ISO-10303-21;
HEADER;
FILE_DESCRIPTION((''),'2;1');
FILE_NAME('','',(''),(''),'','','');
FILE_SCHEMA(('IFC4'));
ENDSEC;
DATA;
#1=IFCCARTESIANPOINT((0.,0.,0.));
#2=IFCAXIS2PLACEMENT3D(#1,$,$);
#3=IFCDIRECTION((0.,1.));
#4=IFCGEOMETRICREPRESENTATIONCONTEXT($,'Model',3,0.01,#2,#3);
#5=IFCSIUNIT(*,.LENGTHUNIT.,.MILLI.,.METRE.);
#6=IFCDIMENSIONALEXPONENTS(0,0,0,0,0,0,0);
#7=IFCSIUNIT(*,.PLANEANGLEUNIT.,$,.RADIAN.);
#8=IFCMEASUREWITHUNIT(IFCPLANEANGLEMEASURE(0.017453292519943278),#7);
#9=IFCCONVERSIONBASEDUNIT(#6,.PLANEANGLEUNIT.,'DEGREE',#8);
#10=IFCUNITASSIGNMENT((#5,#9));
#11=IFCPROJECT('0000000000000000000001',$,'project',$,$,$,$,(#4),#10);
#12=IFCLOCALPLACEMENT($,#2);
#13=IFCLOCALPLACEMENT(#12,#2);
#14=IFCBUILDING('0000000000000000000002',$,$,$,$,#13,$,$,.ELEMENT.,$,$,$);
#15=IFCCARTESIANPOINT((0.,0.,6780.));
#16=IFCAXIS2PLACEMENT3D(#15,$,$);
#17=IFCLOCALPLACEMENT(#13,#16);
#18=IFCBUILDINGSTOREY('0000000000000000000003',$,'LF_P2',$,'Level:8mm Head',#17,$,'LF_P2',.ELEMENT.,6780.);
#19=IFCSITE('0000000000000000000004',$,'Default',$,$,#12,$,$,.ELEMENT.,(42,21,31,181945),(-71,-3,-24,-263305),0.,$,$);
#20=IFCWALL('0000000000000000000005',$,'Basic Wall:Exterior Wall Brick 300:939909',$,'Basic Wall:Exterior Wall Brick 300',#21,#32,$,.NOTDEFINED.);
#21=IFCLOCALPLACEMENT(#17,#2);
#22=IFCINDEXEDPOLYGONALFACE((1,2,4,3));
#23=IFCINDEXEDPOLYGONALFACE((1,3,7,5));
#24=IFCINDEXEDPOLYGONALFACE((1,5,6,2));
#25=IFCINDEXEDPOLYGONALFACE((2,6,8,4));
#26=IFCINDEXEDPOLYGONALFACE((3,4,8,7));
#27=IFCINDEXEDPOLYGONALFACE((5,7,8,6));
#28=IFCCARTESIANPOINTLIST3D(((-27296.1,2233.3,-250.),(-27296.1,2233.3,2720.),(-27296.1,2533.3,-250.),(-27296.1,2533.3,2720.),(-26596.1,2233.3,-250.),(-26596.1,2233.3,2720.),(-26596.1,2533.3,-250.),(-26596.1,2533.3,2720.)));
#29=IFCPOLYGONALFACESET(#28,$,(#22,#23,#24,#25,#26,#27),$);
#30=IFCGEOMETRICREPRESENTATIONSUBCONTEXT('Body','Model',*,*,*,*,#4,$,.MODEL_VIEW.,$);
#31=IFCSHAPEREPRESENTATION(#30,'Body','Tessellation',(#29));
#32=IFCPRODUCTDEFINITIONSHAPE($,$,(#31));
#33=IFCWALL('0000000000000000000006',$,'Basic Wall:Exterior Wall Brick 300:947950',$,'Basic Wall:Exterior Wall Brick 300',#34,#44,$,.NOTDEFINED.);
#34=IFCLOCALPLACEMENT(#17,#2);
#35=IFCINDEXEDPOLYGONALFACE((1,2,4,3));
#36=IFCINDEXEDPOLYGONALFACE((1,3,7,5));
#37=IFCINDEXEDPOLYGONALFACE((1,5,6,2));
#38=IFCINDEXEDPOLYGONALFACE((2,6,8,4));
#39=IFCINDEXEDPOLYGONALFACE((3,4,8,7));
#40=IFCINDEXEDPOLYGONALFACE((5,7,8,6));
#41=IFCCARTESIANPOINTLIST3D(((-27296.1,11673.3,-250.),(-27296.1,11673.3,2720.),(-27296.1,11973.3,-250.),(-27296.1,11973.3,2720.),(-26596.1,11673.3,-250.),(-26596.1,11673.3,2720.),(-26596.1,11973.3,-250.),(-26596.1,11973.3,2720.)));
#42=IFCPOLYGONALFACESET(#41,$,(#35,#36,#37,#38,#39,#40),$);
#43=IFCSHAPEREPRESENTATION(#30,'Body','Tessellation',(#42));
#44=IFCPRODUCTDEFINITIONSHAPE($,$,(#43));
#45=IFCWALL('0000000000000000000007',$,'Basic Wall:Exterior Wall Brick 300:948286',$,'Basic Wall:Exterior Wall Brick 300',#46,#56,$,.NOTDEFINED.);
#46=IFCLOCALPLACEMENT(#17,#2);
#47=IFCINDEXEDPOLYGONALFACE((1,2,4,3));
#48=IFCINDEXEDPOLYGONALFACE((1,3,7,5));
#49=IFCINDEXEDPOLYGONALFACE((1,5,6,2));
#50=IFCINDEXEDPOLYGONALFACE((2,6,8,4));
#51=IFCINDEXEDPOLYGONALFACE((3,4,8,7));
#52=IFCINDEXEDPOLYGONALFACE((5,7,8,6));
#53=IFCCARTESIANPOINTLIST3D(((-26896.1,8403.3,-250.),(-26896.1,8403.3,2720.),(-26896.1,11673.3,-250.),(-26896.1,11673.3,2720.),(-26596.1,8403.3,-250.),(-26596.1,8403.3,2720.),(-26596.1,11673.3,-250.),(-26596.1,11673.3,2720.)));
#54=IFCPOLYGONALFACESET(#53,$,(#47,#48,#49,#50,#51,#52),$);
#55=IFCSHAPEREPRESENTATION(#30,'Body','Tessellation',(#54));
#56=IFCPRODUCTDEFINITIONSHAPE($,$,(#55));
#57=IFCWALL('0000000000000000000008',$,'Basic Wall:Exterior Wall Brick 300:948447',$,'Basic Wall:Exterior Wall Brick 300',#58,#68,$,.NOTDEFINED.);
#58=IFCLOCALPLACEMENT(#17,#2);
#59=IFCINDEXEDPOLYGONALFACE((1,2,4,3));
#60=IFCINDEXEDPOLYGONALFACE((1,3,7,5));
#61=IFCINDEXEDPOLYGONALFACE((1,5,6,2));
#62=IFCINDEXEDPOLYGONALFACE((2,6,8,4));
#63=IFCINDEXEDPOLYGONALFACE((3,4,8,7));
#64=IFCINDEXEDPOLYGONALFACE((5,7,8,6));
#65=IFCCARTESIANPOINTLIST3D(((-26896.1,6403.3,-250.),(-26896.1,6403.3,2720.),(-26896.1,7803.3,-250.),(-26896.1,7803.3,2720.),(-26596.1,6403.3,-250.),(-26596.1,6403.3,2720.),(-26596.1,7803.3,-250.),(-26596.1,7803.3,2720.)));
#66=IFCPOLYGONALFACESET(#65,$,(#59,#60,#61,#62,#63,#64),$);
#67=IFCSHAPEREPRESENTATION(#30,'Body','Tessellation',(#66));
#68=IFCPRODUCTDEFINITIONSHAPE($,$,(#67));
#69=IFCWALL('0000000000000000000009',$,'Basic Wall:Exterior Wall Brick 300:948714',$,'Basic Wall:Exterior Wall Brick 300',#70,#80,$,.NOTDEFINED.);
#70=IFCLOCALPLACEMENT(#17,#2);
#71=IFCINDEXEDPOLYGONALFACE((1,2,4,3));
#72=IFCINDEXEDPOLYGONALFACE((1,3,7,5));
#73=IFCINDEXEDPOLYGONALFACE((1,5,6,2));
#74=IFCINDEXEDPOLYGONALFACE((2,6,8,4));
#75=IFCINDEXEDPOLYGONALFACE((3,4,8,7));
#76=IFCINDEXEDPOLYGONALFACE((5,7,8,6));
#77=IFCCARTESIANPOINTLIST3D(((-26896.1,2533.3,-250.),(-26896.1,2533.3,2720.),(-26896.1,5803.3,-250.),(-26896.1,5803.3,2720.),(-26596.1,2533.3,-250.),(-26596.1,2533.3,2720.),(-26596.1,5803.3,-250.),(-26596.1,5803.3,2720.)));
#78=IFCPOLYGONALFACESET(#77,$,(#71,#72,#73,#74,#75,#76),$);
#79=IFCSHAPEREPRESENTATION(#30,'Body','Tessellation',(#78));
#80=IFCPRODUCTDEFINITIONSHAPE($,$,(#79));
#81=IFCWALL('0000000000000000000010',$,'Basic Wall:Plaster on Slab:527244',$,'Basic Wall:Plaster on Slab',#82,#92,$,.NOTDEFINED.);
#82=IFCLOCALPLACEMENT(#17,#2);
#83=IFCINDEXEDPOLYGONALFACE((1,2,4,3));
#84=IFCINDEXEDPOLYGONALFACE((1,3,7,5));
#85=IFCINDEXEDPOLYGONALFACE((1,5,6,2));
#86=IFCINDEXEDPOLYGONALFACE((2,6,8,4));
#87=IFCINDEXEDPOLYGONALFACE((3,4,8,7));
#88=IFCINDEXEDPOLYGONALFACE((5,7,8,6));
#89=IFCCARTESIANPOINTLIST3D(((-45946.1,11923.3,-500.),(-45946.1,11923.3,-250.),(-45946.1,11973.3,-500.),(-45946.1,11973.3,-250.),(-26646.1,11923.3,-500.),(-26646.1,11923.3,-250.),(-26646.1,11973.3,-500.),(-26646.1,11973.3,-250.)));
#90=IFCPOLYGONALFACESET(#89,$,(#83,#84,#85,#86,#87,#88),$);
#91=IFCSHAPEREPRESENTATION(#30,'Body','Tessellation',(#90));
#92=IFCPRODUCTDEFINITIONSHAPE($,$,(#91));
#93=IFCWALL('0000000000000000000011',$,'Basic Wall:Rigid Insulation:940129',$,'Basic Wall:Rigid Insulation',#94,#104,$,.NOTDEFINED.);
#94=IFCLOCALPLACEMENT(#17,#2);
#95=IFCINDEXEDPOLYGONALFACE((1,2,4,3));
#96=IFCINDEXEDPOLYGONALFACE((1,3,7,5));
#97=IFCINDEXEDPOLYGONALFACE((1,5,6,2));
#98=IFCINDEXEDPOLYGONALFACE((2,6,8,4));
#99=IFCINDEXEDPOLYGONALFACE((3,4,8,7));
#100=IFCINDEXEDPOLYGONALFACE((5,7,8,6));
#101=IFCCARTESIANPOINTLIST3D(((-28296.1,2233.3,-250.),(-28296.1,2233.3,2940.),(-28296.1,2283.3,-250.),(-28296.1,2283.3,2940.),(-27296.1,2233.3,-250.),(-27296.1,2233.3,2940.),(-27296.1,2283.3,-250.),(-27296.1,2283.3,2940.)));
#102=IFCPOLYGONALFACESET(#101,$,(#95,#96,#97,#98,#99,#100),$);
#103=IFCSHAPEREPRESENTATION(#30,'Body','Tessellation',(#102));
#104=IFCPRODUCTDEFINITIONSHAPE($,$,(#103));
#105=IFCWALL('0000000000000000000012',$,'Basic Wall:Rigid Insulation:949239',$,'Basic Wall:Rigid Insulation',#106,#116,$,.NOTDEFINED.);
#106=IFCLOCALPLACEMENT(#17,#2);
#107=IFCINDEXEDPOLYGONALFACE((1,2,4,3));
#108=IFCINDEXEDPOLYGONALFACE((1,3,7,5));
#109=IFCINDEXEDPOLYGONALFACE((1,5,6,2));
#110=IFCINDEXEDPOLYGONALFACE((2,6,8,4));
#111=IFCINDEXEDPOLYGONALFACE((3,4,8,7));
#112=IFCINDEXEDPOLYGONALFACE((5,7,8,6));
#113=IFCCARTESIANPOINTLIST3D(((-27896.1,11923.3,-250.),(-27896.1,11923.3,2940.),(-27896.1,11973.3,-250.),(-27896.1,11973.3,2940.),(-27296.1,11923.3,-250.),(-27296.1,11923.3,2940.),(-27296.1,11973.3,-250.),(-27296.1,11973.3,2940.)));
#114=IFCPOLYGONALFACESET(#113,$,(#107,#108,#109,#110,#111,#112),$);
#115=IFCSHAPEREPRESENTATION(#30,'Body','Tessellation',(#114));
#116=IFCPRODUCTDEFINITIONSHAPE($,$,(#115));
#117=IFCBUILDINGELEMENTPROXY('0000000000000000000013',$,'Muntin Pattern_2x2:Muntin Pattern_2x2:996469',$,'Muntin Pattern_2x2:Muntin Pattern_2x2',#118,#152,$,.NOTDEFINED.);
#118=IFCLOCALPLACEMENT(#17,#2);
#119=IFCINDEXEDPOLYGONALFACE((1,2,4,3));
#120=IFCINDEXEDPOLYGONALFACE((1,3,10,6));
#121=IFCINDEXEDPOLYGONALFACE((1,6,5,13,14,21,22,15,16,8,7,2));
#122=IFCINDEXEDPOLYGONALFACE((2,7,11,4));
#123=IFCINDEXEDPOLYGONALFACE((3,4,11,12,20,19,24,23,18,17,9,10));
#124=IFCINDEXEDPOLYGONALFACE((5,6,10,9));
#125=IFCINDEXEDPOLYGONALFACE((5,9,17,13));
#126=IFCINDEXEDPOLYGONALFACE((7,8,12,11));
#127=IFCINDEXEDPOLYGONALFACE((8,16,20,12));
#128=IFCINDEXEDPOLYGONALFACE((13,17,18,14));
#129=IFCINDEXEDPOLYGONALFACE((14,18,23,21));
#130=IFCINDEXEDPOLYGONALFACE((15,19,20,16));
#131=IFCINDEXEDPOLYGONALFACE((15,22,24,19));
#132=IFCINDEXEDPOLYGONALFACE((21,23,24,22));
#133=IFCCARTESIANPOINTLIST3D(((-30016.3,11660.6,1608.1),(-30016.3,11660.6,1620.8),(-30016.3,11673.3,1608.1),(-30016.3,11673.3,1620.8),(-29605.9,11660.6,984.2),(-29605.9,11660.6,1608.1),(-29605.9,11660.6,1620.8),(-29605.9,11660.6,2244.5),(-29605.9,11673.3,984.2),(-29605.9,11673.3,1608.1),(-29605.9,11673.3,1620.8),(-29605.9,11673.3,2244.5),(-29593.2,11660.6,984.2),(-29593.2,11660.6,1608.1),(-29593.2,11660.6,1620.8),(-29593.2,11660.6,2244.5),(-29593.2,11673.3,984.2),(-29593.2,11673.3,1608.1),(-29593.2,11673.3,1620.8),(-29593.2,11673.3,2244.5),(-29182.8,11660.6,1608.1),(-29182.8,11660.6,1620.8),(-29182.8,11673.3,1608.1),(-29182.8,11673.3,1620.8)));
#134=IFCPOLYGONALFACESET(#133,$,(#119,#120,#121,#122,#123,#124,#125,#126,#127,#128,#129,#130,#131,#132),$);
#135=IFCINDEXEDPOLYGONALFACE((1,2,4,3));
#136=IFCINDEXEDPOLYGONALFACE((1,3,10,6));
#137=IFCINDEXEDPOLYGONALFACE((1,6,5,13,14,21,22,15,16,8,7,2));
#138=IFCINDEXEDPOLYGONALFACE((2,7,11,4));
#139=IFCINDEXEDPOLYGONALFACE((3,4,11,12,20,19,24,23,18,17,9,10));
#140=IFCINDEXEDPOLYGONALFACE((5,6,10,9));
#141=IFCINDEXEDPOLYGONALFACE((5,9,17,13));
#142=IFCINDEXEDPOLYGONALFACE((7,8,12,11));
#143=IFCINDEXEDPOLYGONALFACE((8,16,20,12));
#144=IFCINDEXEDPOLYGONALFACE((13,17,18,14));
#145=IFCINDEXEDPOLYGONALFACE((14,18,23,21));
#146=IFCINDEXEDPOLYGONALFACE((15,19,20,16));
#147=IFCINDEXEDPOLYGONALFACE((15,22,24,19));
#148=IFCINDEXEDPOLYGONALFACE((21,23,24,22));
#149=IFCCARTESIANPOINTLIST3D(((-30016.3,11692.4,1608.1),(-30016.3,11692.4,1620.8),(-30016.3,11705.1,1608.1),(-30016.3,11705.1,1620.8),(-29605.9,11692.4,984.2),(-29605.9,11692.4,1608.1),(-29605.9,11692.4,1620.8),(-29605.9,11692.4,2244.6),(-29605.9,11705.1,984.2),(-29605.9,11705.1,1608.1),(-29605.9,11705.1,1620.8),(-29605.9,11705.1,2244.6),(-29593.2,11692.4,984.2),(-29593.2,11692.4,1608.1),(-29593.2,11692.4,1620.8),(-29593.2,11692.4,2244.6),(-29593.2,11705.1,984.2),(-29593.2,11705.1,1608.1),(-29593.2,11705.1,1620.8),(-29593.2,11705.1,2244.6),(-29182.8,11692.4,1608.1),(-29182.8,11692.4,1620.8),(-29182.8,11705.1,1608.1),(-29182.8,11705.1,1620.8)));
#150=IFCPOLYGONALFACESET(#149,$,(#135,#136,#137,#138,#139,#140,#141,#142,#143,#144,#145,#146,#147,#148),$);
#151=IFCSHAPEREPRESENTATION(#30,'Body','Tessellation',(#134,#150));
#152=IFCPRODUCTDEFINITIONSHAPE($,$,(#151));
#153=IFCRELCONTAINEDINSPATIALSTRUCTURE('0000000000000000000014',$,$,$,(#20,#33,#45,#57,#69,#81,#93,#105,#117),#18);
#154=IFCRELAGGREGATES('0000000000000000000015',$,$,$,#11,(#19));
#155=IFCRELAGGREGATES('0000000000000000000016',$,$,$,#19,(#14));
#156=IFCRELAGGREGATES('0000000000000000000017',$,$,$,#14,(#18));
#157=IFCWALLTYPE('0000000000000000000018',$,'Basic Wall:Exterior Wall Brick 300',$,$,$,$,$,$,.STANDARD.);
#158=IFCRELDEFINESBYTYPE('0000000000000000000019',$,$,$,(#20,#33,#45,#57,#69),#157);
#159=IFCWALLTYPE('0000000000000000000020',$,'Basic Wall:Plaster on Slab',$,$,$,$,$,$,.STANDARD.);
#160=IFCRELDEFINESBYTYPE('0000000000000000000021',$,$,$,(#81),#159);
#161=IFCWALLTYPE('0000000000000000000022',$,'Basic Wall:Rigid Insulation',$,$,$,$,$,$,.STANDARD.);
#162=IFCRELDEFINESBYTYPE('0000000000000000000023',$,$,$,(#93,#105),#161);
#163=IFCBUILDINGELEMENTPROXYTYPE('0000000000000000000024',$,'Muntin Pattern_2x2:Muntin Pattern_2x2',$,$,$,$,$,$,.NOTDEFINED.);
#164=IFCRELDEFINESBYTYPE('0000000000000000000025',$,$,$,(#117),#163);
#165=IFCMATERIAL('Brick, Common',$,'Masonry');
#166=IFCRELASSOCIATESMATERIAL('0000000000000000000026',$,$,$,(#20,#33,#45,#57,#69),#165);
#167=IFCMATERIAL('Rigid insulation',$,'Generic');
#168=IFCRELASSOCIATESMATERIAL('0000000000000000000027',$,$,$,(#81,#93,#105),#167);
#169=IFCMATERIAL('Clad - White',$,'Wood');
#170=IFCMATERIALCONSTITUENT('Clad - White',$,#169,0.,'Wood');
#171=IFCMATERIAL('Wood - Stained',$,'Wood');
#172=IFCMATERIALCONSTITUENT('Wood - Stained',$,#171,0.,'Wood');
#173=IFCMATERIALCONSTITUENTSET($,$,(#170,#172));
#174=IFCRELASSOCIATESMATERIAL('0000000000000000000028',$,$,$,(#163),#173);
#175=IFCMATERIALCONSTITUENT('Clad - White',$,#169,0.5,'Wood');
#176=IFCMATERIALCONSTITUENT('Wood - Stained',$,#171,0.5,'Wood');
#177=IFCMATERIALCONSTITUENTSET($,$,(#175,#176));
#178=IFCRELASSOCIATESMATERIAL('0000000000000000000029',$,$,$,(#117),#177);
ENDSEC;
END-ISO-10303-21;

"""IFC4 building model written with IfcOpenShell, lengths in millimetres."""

from ifc_helpers import new_model, entity, si_unit, converted_unit, direction, frame, origin, place, context, subcontext, project, spatial, indexed_curve, outline, extrude, source, transform, mapped, material, constituent, constituent_set, type_object, type_shapes, element, save


model = new_model("IFC4")

# Units and contexts
model_context = context("Model", 3, precision=0.01, world=origin(), true_north=direction((0.0, 1.0)))
body_context = subcontext(model_context, "Body", "Model", "MODEL_VIEW")
ifc_project = project(units=[si_unit("LENGTHUNIT", "METRE", prefix="MILLI"), converted_unit("PLANEANGLEUNIT", "DEGREE", entity("IfcPlaneAngleMeasure", 0.017453292519943278), si_unit("PLANEANGLEUNIT", "RADIAN"), dimensions=[0, 0, 0, 0, 0, 0, 0])], contexts=[model_context])

# Site, building, storey
site_placement = place(None, origin())
site = spatial("IfcSite", under=ifc_project, at=site_placement, Name="Default", CompositionType="ELEMENT", RefLatitude=(42, 21, 31, 181945), RefLongitude=(-71, -3, -24, -263305), RefElevation=0.0)
building_placement = place(site_placement, origin())
building = spatial("IfcBuilding", under=site, at=building_placement, CompositionType="ELEMENT")
storey_placement = place(building_placement, frame((0.0, 0.0, 6780.0)))
storey = spatial("IfcBuildingStorey", under=building, at=storey_placement, Name="LF_P2", ObjectType="Level:8mm Head", LongName="LF_P2", CompositionType="ELEMENT", Elevation=6780.0)

# Walls
ifc_material_1 = material(Name="Brick, Common", Category="Masonry")
wall_type_1 = type_object("IfcWallType", Name="Basic Wall:Exterior Wall Brick 300", PredefinedType="STANDARD")
wall_1_placement = place(storey_placement, frame((-27296.1, 2383.3, -250.0)))
element("IfcWall", 1, at=wall_1_placement, inside=storey, type_object=wall_type_1, material=ifc_material_1, Name="Basic Wall:Exterior Wall Brick 300:939909", ObjectType="Basic Wall:Exterior Wall Brick 300", PredefinedType="NOTDEFINED", context=body_context, shape_type="SweptSolid", body=[
    extrude(outline(indexed_curve([(700.0, 150.0), (0.0, 150.0), (0.0, -150.0), (700.0, -150.0), (700.0, 150.0)], self_intersect=False)), origin(), (0.0, 0.0, 1.0), 2970.0),
])
wall_2_placement = place(storey_placement, frame((-27296.1, 11823.3, -250.0)))
element("IfcWall", 2, at=wall_2_placement, inside=storey, type_object=wall_type_1, material=ifc_material_1, Name="Basic Wall:Exterior Wall Brick 300:947950", ObjectType="Basic Wall:Exterior Wall Brick 300", PredefinedType="NOTDEFINED", context=body_context, shape_type="SweptSolid", body=[
    extrude(outline(indexed_curve([(700.0, 150.0), (0.0, 150.0), (0.0, -150.0), (700.0, -150.0), (700.0, 150.0)], self_intersect=False)), origin(), (0.0, 0.0, 1.0), 2970.0),
])
wall_3_placement = place(storey_placement, frame((-26746.1, 11673.3, -250.0), z_axis=(0.0, 0.0, 1.0), x_axis=(0.0, -1.0, 0.0)))
element("IfcWall", 3, at=wall_3_placement, inside=storey, type_object=wall_type_1, material=ifc_material_1, Name="Basic Wall:Exterior Wall Brick 300:948286", ObjectType="Basic Wall:Exterior Wall Brick 300", PredefinedType="NOTDEFINED", context=body_context, shape_type="SweptSolid", body=[
    extrude(outline(indexed_curve([(3270.0, 150.0), (0.0, 150.0), (0.0, -150.0), (3270.0, -150.0), (3270.0, 150.0)], self_intersect=False)), origin(), (0.0, 0.0, 1.0), 2970.0),
])
wall_4_placement = place(storey_placement, frame((-26746.1, 7803.3, -250.0), z_axis=(0.0, 0.0, 1.0), x_axis=(0.0, -1.0, 0.0)))
element("IfcWall", 4, at=wall_4_placement, inside=storey, type_object=wall_type_1, material=ifc_material_1, Name="Basic Wall:Exterior Wall Brick 300:948447", ObjectType="Basic Wall:Exterior Wall Brick 300", PredefinedType="NOTDEFINED", context=body_context, shape_type="SweptSolid", body=[
    extrude(outline(indexed_curve([(1400.0, 150.0), (0.0, 150.0), (0.0, -150.0), (1400.0, -150.0), (1400.0, 150.0)], self_intersect=False)), origin(), (0.0, 0.0, 1.0), 2970.0),
])
wall_5_placement = place(storey_placement, frame((-26746.1, 5803.3, -250.0), z_axis=(0.0, 0.0, 1.0), x_axis=(0.0, -1.0, 0.0)))
element("IfcWall", 5, at=wall_5_placement, inside=storey, type_object=wall_type_1, material=ifc_material_1, Name="Basic Wall:Exterior Wall Brick 300:948714", ObjectType="Basic Wall:Exterior Wall Brick 300", PredefinedType="NOTDEFINED", context=body_context, shape_type="SweptSolid", body=[
    extrude(outline(indexed_curve([(3270.0, 150.0), (0.0, 150.0), (0.0, -150.0), (3270.0, -150.0), (3270.0, 150.0)], self_intersect=False)), origin(), (0.0, 0.0, 1.0), 2970.0),
])
ifc_material_2 = material(Name="Rigid insulation", Category="Generic")
wall_type_2 = type_object("IfcWallType", Name="Basic Wall:Plaster on Slab", PredefinedType="STANDARD")
wall_6_placement = place(storey_placement, frame((-26646.1, 11948.3, -500.0), z_axis=(0.0, 0.0, 1.0), x_axis=(-1.0, 0.0, 0.0)))
element("IfcWall", 6, at=wall_6_placement, inside=storey, type_object=wall_type_2, material=ifc_material_2, Name="Basic Wall:Plaster on Slab:527244", ObjectType="Basic Wall:Plaster on Slab", PredefinedType="NOTDEFINED", context=body_context, shape_type="SweptSolid", body=[
    extrude(outline(indexed_curve([(19300.0, 25.0), (0.0, 25.0), (0.0, -25.0), (19300.0, -25.0), (19300.0, 25.0)], self_intersect=False)), origin(), (0.0, 0.0, 1.0), 250.0),
])
wall_type_3 = type_object("IfcWallType", Name="Basic Wall:Rigid Insulation", PredefinedType="STANDARD")
wall_7_placement = place(storey_placement, frame((-28296.1, 2258.3, -250.0)))
element("IfcWall", 7, at=wall_7_placement, inside=storey, type_object=wall_type_3, material=ifc_material_2, Name="Basic Wall:Rigid Insulation:940129", ObjectType="Basic Wall:Rigid Insulation", PredefinedType="NOTDEFINED", context=body_context, shape_type="SweptSolid", body=[
    extrude(outline(indexed_curve([(1000.0, 25.0), (0.0, 25.0), (0.0, -25.0), (1000.0, -25.0), (1000.0, 25.0)], self_intersect=False)), origin(), (0.0, 0.0, 1.0), 3190.0),
])
wall_8_placement = place(storey_placement, frame((-27896.1, 11948.3, -250.0)))
element("IfcWall", 8, at=wall_8_placement, inside=storey, type_object=wall_type_3, material=ifc_material_2, Name="Basic Wall:Rigid Insulation:949239", ObjectType="Basic Wall:Rigid Insulation", PredefinedType="NOTDEFINED", context=body_context, shape_type="SweptSolid", body=[
    extrude(outline(indexed_curve([(600.0, 25.0), (0.0, 25.0), (0.0, -25.0), (600.0, -25.0), (600.0, 25.0)], self_intersect=False)), origin(), (0.0, 0.0, 1.0), 3190.0),
])

# Building element proxy
ifc_material_3 = material(Name="Clad - White", Category="Wood")
ifc_constituent_1 = constituent(ifc_material_3, Name="Clad - White", Category="Wood", fraction=0.5)
ifc_material_4 = material(Name="Wood - Stained", Category="Wood")
ifc_constituent_2 = constituent(ifc_material_4, Name="Wood - Stained", Category="Wood", fraction=0.5)
ifc_constituent_set_1 = constituent_set(constituents=[ifc_constituent_1, ifc_constituent_2])
ifc_constituent_3 = constituent(ifc_material_3, Name="Clad - White", Category="Wood", fraction=0.0)
ifc_constituent_4 = constituent(ifc_material_4, Name="Wood - Stained", Category="Wood", fraction=0.0)
ifc_constituent_set_2 = constituent_set(constituents=[ifc_constituent_3, ifc_constituent_4])
building_element_proxy_type_1 = type_object("IfcBuildingElementProxyType", Name="Muntin Pattern_2x2:Muntin Pattern_2x2", PredefinedType="NOTDEFINED", material=ifc_constituent_set_2)
shared_shape_1 = source(origin(), body_context, "Body", "SweptSolid", [
    extrude(outline(indexed_curve([(6.4, -6.4), (630.1, -6.4), (630.1, 6.3), (6.4, 6.3), (6.4, 416.7), (-6.3, 416.7), (-6.3, 6.3), (-630.2, 6.3), (-630.2, -6.4), (-6.3, -6.4), (-6.3, -416.7), (6.4, -416.7), (6.4, -6.4)], self_intersect=False)), frame((0.0, -22.2, 630.1), z_axis=(0.0, 1.0, 0.0), x_axis=(0.0, 0.0, 1.0)), (0.0, 0.0, 1.0), 12.7),
    extrude(outline(indexed_curve([(6.4, -6.4), (630.2, -6.4), (630.2, 6.3), (6.4, 6.3), (6.4, 416.7), (-6.3, 416.7), (-6.3, 6.3), (-630.2, 6.3), (-630.2, -6.4), (-6.3, -6.4), (-6.3, -416.7), (6.4, -416.7), (6.4, -6.4)], self_intersect=False)), frame((0.0, 9.5, 630.2), z_axis=(0.0, 1.0, 0.0), x_axis=(0.0, 0.0, 1.0)), (0.0, 0.0, 1.0), 12.7),
])
type_shapes(building_element_proxy_type_1, [shared_shape_1])
proxy_1_placement = place(storey_placement, frame((-29599.5, 11682.9, 984.3)))
element("IfcBuildingElementProxy", 9, at=proxy_1_placement, inside=storey, type_object=building_element_proxy_type_1, material=ifc_constituent_set_1, Name="Muntin Pattern_2x2:Muntin Pattern_2x2:996469", ObjectType="Muntin Pattern_2x2:Muntin Pattern_2x2", PredefinedType="NOTDEFINED", context=body_context, shape_type="MappedRepresentation", body=[
    mapped(shared_shape_1, transform((0.0, 0.0, 0.0), scale=1.0)),
])

save(model, "model.ifc")
